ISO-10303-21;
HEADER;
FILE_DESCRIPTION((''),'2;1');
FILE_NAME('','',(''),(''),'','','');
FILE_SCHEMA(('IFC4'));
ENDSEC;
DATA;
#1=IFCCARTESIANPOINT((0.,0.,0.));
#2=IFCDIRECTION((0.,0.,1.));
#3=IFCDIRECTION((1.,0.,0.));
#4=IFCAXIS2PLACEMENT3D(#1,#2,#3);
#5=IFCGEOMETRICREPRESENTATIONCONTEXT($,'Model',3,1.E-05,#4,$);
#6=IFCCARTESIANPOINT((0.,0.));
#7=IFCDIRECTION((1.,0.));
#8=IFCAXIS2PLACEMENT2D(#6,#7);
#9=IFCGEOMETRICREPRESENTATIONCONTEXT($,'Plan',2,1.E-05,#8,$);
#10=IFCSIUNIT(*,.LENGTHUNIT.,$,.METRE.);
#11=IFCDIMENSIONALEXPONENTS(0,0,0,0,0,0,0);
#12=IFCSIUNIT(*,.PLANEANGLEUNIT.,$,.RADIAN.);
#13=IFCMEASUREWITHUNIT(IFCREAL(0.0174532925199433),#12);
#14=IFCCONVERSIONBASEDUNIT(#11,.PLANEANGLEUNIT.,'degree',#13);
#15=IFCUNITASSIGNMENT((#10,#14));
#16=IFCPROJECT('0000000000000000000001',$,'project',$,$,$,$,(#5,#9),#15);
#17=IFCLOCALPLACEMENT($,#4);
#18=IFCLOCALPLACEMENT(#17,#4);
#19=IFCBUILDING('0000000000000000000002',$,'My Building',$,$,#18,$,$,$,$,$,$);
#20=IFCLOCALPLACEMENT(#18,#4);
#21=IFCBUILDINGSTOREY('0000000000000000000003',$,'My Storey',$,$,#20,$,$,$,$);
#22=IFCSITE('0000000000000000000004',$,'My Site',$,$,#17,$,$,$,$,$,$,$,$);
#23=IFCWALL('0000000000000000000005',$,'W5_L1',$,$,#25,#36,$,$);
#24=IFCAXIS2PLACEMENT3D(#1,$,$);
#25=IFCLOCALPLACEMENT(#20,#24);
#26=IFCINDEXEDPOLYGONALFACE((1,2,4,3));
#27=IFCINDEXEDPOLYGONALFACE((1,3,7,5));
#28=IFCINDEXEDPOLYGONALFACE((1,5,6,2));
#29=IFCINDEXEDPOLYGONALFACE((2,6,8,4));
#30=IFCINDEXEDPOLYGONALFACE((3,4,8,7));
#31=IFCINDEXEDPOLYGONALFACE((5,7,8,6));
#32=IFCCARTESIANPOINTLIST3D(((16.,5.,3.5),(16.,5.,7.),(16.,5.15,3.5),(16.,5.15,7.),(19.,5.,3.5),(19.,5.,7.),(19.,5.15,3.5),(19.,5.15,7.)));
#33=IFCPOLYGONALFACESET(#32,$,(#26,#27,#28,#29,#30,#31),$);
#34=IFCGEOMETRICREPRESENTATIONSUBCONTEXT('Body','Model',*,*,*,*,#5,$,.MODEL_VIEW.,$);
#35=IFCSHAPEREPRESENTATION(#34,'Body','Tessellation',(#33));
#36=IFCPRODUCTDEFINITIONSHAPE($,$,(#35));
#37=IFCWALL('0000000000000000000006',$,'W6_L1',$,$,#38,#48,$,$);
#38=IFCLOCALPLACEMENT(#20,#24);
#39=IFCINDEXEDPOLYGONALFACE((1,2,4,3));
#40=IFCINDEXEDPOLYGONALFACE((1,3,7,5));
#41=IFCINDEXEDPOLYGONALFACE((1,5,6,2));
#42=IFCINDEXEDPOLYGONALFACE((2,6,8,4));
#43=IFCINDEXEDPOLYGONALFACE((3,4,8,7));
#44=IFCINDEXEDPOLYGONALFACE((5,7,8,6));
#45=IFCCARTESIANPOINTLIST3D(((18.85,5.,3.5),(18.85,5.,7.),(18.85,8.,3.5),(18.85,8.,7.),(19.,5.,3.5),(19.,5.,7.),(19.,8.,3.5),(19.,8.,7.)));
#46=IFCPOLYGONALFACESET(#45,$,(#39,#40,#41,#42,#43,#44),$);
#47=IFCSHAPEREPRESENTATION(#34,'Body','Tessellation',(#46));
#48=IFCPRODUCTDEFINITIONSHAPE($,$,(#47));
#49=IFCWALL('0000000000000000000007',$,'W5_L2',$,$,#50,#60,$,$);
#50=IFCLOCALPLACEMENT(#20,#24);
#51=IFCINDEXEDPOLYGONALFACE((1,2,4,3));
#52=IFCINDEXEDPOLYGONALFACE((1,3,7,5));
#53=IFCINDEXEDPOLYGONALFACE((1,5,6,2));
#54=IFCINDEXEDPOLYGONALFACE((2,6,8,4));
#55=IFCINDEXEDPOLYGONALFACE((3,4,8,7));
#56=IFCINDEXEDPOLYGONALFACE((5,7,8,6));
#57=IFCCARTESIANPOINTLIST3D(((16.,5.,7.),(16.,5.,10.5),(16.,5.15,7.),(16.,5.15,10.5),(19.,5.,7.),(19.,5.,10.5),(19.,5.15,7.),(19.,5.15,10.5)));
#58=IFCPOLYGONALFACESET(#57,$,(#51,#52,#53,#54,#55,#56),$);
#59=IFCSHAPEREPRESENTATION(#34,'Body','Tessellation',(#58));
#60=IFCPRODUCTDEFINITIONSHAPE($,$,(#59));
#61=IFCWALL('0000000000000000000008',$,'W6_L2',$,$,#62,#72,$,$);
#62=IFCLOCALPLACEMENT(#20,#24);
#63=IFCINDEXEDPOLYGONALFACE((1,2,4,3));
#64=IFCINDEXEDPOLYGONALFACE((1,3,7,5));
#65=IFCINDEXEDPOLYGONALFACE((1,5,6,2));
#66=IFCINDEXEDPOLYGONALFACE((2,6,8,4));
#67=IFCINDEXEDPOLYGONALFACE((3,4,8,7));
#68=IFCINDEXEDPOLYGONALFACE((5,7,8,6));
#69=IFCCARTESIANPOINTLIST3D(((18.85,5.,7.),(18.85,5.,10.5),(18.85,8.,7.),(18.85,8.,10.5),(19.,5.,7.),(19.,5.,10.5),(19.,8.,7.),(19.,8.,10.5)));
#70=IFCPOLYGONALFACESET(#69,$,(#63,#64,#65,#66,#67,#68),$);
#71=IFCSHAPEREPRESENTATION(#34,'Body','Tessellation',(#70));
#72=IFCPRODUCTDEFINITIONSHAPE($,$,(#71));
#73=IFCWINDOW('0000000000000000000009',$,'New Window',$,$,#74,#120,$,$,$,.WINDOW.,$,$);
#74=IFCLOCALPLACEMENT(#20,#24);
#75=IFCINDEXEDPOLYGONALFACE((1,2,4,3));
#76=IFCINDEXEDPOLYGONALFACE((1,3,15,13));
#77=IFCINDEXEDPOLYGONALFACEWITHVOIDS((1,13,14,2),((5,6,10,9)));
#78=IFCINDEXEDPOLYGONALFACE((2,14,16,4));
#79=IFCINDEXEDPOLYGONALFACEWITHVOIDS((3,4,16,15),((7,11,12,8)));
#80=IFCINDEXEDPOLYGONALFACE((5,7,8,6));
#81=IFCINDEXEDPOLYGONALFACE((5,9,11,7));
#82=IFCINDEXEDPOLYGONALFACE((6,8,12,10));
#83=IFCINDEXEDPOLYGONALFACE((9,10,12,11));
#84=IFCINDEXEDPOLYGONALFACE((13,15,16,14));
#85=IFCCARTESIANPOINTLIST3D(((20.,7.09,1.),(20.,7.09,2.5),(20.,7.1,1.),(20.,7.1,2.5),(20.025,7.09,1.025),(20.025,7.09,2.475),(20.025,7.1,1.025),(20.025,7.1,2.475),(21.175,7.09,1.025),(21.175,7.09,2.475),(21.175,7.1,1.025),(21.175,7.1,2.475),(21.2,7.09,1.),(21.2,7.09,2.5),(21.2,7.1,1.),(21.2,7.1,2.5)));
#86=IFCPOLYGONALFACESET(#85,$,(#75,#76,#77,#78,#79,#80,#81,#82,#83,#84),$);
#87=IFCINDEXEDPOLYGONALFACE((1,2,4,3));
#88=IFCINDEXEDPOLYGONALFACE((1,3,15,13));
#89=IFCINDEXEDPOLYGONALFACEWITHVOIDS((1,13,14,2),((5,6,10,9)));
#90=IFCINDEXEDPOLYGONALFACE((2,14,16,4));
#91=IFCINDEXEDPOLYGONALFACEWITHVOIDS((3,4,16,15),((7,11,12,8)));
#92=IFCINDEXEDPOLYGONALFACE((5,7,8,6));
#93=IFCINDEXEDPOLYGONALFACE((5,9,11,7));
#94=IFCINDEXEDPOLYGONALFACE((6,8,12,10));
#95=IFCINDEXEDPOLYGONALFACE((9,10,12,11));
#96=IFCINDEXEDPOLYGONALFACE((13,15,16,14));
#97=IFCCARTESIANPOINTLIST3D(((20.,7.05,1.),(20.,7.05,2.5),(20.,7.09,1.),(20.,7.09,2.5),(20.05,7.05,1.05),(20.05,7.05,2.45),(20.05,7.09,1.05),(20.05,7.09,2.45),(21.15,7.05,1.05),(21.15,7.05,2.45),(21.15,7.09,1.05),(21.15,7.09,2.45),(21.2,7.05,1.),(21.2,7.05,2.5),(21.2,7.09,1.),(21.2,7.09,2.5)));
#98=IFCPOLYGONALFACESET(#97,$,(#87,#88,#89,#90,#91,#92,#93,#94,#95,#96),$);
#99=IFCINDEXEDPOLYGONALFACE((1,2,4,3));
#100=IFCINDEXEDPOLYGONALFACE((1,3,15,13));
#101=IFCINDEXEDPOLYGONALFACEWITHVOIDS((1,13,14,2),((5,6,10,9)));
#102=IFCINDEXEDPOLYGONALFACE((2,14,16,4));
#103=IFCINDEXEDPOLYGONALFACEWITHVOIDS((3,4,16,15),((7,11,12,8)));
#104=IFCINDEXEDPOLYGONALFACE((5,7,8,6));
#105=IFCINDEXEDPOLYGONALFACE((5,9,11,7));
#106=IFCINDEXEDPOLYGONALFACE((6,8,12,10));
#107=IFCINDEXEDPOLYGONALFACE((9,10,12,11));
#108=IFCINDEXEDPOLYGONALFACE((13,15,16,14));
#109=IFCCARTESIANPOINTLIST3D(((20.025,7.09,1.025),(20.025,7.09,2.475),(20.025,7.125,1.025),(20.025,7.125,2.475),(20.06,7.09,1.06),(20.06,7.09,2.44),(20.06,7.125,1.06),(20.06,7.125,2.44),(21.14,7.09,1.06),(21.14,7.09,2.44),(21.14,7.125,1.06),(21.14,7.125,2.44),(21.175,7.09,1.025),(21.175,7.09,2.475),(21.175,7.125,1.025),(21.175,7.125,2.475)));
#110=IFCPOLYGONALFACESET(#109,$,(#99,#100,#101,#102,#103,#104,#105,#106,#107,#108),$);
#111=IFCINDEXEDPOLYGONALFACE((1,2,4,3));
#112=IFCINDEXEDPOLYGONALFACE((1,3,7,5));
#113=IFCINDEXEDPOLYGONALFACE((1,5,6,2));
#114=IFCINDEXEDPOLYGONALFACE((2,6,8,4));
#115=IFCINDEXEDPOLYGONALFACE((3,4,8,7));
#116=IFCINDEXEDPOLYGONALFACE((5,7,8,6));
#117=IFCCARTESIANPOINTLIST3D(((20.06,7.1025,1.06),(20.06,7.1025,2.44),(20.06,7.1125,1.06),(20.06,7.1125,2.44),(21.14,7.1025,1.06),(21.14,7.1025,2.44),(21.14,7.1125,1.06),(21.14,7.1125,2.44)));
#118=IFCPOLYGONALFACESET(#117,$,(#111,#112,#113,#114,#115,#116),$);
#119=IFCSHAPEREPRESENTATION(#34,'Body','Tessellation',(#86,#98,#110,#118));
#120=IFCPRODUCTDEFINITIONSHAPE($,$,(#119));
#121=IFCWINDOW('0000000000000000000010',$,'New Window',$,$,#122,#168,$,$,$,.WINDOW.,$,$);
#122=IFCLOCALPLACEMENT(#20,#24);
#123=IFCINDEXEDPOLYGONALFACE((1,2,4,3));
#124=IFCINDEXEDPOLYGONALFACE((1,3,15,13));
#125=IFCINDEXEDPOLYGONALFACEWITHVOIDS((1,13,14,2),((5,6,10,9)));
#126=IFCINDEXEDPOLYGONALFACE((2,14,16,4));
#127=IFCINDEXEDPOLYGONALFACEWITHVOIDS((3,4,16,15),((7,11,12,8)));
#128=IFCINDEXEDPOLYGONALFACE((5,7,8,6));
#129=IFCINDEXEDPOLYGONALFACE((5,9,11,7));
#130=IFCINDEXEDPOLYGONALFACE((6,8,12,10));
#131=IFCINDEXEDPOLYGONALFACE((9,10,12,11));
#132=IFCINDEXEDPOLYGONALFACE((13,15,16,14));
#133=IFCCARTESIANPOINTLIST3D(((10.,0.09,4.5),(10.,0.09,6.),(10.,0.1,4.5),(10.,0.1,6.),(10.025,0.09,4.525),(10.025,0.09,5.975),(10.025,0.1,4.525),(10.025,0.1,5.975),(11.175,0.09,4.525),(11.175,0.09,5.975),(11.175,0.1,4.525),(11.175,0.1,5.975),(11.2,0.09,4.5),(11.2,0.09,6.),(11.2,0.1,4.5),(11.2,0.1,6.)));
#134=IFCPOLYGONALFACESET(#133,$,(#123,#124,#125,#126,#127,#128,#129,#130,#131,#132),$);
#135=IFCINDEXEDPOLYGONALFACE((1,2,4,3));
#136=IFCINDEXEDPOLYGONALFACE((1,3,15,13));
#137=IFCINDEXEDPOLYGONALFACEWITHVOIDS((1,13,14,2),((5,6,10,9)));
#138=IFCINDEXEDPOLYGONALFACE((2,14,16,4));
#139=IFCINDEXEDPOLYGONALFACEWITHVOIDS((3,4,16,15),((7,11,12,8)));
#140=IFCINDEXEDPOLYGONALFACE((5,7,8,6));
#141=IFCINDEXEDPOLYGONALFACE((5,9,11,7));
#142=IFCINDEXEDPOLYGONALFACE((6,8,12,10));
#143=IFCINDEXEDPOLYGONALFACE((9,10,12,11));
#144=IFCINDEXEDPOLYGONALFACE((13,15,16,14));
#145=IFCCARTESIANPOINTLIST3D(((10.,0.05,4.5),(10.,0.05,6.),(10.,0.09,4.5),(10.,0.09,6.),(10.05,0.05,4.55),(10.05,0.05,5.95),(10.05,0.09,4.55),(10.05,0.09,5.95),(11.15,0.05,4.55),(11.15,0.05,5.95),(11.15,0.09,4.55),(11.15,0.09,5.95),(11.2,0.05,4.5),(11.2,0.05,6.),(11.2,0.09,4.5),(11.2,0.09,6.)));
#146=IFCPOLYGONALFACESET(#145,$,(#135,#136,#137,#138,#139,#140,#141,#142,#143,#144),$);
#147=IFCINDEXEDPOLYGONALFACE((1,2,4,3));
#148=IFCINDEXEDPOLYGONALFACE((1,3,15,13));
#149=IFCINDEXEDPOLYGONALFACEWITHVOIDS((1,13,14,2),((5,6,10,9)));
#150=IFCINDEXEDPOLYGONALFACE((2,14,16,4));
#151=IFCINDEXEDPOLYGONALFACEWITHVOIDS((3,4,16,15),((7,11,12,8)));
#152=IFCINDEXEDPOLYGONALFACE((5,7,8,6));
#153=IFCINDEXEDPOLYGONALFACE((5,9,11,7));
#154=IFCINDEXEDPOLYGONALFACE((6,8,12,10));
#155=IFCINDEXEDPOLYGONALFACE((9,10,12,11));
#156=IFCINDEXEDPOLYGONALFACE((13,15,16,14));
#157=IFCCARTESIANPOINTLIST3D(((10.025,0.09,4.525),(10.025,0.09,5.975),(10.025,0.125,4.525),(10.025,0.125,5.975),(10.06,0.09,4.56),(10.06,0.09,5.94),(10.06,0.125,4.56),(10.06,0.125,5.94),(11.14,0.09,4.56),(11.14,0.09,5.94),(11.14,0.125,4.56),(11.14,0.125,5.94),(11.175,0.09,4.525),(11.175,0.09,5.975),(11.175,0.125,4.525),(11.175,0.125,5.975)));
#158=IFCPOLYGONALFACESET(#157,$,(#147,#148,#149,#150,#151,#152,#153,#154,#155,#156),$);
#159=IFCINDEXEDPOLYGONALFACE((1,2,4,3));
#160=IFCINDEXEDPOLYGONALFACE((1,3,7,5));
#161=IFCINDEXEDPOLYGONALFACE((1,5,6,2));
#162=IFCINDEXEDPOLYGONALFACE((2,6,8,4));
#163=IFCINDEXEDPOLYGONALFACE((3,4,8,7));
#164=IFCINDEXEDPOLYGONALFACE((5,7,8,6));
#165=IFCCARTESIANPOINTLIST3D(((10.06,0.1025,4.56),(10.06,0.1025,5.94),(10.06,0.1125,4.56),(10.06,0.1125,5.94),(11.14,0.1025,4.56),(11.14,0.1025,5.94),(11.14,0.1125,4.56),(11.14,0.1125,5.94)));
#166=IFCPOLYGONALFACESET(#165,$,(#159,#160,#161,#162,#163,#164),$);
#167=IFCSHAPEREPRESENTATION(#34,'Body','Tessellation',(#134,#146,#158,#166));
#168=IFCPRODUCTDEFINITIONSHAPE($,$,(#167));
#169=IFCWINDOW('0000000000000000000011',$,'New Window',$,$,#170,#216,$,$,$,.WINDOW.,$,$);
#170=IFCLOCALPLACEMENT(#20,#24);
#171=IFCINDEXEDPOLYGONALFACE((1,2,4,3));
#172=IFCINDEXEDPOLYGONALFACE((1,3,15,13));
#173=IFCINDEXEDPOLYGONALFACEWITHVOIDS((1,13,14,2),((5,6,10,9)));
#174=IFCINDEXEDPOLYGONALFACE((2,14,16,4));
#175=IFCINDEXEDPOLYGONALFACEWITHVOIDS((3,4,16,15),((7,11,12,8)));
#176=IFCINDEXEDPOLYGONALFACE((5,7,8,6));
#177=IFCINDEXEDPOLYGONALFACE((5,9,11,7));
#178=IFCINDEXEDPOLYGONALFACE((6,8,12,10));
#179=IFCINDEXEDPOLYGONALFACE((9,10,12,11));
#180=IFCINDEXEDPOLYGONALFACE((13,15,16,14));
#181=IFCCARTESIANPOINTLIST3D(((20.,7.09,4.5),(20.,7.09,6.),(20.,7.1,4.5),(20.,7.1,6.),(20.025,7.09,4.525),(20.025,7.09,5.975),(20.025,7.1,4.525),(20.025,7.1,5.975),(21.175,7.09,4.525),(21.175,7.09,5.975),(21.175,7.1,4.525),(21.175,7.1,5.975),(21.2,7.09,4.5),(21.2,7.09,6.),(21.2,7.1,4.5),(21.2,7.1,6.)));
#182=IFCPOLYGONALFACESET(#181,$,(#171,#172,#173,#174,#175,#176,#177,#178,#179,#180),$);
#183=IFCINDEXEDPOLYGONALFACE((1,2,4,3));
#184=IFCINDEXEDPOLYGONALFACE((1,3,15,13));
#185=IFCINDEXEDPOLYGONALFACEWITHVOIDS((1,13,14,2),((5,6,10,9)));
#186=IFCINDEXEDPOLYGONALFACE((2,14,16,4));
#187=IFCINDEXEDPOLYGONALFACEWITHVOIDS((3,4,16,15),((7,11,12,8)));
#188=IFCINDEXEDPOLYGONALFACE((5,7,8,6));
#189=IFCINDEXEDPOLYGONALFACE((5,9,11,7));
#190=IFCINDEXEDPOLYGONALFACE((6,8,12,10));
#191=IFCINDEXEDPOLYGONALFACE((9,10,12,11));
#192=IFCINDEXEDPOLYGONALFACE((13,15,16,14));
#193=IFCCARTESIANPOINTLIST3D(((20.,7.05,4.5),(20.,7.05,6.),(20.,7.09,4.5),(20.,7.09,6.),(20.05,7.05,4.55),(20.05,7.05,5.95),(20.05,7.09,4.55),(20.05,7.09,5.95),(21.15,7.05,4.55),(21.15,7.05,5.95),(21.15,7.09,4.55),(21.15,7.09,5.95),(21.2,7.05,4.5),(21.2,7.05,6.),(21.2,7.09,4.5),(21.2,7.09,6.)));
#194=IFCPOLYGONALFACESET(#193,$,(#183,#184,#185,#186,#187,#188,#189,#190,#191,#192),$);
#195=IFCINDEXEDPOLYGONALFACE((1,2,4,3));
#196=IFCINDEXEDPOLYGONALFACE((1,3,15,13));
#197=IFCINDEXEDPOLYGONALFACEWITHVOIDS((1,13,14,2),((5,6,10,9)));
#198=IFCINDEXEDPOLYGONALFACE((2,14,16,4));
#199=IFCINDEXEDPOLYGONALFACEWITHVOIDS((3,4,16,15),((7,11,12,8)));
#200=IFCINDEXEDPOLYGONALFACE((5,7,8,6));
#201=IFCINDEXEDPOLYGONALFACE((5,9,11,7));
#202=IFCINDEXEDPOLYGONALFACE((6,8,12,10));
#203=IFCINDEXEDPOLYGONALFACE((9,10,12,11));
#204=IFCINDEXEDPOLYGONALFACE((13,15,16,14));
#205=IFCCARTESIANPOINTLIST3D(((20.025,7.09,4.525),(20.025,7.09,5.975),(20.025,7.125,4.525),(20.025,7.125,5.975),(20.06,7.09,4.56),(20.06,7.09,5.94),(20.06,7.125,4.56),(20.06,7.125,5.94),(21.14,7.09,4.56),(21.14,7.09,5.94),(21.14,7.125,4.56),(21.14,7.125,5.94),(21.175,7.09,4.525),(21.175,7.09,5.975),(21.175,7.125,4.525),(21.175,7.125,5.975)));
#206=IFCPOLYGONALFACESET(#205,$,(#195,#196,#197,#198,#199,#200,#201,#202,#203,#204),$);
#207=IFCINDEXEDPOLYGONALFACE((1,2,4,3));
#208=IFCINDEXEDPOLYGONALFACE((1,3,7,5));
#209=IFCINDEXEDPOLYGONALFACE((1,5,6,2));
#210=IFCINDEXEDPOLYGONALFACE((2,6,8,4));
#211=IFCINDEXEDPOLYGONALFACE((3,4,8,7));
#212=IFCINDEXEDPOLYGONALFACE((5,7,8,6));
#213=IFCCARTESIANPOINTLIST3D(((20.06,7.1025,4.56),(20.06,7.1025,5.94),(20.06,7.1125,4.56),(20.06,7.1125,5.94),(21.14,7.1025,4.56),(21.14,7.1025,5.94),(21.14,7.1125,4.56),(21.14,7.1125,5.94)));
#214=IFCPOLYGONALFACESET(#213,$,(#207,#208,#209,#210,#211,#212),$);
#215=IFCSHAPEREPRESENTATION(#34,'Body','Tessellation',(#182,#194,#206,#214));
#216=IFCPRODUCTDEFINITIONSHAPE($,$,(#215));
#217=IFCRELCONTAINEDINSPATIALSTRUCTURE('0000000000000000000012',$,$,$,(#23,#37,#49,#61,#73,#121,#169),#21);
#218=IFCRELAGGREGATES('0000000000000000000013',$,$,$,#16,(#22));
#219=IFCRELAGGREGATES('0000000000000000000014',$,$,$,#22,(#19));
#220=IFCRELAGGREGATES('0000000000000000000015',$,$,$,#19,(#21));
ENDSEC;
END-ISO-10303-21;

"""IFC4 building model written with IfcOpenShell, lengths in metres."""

from ifc_helpers import new_model, entity, si_unit, converted_unit, frame, origin_with_axes, origin_2d_with_axis, place, context, subcontext, project, spatial, line, indexed_curve, outline, extrude, element, save


model = new_model("IFC4")

# Units and contexts
model_context = context("Model", 3, precision=1e-05, world=origin_with_axes())
plan_context = context("Plan", 2, precision=1e-05, world=origin_2d_with_axis())
body_context = subcontext(model_context, "Body", "Model", "MODEL_VIEW")
ifc_project = project(units=[si_unit("LENGTHUNIT", "METRE"), converted_unit("PLANEANGLEUNIT", "degree", entity("IfcReal", 0.0174532925199433), si_unit("PLANEANGLEUNIT", "RADIAN"), dimensions=[0, 0, 0, 0, 0, 0, 0])], contexts=[model_context, plan_context])

# Site, building, storey
site_placement = place(None, origin_with_axes())
site = spatial("IfcSite", under=ifc_project, at=site_placement, Name="My Site")
building_placement = place(site_placement, origin_with_axes())
building = spatial("IfcBuilding", under=site, at=building_placement, Name="My Building")
storey_placement = place(building_placement, origin_with_axes())
storey = spatial("IfcBuildingStorey", under=building, at=storey_placement, Name="My Storey")

# Walls
for number, where, z_axis, x_axis, name in (
    (1, (16.0, 5.0, 3.5), (0.0, 0.0, 1.0), (1.0, 0.0, 0.0), "W5_L1"),
    (2, (19.0, 5.0, 3.5), (0.0, 0.0, 1.0), (0.0, 1.0, 0.0), "W6_L1"),
):
    element("IfcWall", number, at=place(storey_placement, frame(where, z_axis=z_axis, x_axis=x_axis)), inside=storey, Name=name, context=body_context, shape_type="SweptSolid", body=[
        extrude(outline(indexed_curve([(0.0, 0.0), (0.0, 0.15), (3.0, 0.15), (3.0, 0.0), (0.0, 0.0)], self_intersect=False)), origin_with_axes(), (0.0, 0.0, 1.0), 3.5),
    ])
for number, where, z_axis, x_axis, name in (
    (3, (16.0, 5.0, 7.0), (0.0, 0.0, 1.0), (1.0, 0.0, 0.0), "W5_L2"),
    (4, (19.0, 5.0, 7.0), (0.0, 0.0, 1.0), (0.0, 1.0, 0.0), "W6_L2"),
):
    element("IfcWall", number, at=place(storey_placement, frame(where, z_axis=z_axis, x_axis=x_axis)), inside=storey, Name=name, context=body_context, shape_type="SweptSolid", body=[
        extrude(outline(indexed_curve([(0.0, 0.0), (0.0, 0.15), (3.0, 0.15), (3.0, 0.0), (0.0, 0.0)], self_intersect=False)), origin_with_axes(), (0.0, 0.0, 1.0), 3.5),
    ])

# Windows
for number, where, z_axis, x_axis, name in (
    (5, (20.0, 7.0, 1.0), (0.0, 0.0, 1.0), (1.0, 0.0, 0.0), "New Window"),
    (6, (10.0, 0.0, 4.5), (0.0, 0.0, 1.0), (1.0, 0.0, 0.0), "New Window"),
    (7, (20.0, 7.0, 4.5), (0.0, 0.0, 1.0), (1.0, 0.0, 0.0), "New Window"),
):
    element("IfcWindow", number, at=place(storey_placement, frame(where, z_axis=z_axis, x_axis=x_axis)), inside=storey, Name=name, PredefinedType="WINDOW", context=body_context, shape_type="SweptSolid", body=[
        extrude(outline(indexed_curve([(0.0, 0.0), (1.2, 0.0), (1.2, 1.5), (0.0, 1.5)], segments=[line(1, 2, 3, 4, 1)]), holes=[indexed_curve([(0.025, 0.025), (1.175, 0.025), (1.175, 1.475), (0.025, 1.475)], segments=[line(1, 2, 3, 4, 1)])]), frame((0.0, 0.09, 0.0), z_axis=(0.0, -1.0, 0.0), x_axis=(1.0, 0.0, 0.0)), (0.0, 0.0, -1.0), 0.01),
        extrude(outline(indexed_curve([(0.0, 0.0), (1.2, 0.0), (1.2, 1.5), (0.0, 1.5)], segments=[line(1, 2, 3, 4, 1)]), holes=[indexed_curve([(0.05, 0.05), (1.15, 0.05), (1.15, 1.45), (0.05, 1.45)], segments=[line(1, 2, 3, 4, 1)])]), frame((0.0, 0.05, 0.0), z_axis=(0.0, -1.0, 0.0), x_axis=(1.0, 0.0, 0.0)), (0.0, 0.0, -1.0), 0.04),
        extrude(outline(indexed_curve([(0.0, 0.0), (1.15, 0.0), (1.15, 1.45), (0.0, 1.45)], segments=[line(1, 2, 3, 4, 1)]), holes=[indexed_curve([(0.035, 0.035), (1.115, 0.035), (1.115, 1.415), (0.035, 1.415)], segments=[line(1, 2, 3, 4, 1)])]), frame((0.025, 0.09, 0.025), z_axis=(0.0, -1.0, 0.0), x_axis=(1.0, 0.0, 0.0)), (0.0, 0.0, -1.0), 0.035),
        extrude(outline(indexed_curve([(0.035, 0.035), (1.115, 0.035), (1.115, 1.415), (0.035, 1.415)], segments=[line(1, 2, 3, 4, 1)])), frame((0.025, 0.1025, 0.025), z_axis=(0.0, -1.0, 0.0), x_axis=(1.0, 0.0, 0.0)), (0.0, 0.0, -1.0), 0.01),
    ])

save(model, "model.ifc")
